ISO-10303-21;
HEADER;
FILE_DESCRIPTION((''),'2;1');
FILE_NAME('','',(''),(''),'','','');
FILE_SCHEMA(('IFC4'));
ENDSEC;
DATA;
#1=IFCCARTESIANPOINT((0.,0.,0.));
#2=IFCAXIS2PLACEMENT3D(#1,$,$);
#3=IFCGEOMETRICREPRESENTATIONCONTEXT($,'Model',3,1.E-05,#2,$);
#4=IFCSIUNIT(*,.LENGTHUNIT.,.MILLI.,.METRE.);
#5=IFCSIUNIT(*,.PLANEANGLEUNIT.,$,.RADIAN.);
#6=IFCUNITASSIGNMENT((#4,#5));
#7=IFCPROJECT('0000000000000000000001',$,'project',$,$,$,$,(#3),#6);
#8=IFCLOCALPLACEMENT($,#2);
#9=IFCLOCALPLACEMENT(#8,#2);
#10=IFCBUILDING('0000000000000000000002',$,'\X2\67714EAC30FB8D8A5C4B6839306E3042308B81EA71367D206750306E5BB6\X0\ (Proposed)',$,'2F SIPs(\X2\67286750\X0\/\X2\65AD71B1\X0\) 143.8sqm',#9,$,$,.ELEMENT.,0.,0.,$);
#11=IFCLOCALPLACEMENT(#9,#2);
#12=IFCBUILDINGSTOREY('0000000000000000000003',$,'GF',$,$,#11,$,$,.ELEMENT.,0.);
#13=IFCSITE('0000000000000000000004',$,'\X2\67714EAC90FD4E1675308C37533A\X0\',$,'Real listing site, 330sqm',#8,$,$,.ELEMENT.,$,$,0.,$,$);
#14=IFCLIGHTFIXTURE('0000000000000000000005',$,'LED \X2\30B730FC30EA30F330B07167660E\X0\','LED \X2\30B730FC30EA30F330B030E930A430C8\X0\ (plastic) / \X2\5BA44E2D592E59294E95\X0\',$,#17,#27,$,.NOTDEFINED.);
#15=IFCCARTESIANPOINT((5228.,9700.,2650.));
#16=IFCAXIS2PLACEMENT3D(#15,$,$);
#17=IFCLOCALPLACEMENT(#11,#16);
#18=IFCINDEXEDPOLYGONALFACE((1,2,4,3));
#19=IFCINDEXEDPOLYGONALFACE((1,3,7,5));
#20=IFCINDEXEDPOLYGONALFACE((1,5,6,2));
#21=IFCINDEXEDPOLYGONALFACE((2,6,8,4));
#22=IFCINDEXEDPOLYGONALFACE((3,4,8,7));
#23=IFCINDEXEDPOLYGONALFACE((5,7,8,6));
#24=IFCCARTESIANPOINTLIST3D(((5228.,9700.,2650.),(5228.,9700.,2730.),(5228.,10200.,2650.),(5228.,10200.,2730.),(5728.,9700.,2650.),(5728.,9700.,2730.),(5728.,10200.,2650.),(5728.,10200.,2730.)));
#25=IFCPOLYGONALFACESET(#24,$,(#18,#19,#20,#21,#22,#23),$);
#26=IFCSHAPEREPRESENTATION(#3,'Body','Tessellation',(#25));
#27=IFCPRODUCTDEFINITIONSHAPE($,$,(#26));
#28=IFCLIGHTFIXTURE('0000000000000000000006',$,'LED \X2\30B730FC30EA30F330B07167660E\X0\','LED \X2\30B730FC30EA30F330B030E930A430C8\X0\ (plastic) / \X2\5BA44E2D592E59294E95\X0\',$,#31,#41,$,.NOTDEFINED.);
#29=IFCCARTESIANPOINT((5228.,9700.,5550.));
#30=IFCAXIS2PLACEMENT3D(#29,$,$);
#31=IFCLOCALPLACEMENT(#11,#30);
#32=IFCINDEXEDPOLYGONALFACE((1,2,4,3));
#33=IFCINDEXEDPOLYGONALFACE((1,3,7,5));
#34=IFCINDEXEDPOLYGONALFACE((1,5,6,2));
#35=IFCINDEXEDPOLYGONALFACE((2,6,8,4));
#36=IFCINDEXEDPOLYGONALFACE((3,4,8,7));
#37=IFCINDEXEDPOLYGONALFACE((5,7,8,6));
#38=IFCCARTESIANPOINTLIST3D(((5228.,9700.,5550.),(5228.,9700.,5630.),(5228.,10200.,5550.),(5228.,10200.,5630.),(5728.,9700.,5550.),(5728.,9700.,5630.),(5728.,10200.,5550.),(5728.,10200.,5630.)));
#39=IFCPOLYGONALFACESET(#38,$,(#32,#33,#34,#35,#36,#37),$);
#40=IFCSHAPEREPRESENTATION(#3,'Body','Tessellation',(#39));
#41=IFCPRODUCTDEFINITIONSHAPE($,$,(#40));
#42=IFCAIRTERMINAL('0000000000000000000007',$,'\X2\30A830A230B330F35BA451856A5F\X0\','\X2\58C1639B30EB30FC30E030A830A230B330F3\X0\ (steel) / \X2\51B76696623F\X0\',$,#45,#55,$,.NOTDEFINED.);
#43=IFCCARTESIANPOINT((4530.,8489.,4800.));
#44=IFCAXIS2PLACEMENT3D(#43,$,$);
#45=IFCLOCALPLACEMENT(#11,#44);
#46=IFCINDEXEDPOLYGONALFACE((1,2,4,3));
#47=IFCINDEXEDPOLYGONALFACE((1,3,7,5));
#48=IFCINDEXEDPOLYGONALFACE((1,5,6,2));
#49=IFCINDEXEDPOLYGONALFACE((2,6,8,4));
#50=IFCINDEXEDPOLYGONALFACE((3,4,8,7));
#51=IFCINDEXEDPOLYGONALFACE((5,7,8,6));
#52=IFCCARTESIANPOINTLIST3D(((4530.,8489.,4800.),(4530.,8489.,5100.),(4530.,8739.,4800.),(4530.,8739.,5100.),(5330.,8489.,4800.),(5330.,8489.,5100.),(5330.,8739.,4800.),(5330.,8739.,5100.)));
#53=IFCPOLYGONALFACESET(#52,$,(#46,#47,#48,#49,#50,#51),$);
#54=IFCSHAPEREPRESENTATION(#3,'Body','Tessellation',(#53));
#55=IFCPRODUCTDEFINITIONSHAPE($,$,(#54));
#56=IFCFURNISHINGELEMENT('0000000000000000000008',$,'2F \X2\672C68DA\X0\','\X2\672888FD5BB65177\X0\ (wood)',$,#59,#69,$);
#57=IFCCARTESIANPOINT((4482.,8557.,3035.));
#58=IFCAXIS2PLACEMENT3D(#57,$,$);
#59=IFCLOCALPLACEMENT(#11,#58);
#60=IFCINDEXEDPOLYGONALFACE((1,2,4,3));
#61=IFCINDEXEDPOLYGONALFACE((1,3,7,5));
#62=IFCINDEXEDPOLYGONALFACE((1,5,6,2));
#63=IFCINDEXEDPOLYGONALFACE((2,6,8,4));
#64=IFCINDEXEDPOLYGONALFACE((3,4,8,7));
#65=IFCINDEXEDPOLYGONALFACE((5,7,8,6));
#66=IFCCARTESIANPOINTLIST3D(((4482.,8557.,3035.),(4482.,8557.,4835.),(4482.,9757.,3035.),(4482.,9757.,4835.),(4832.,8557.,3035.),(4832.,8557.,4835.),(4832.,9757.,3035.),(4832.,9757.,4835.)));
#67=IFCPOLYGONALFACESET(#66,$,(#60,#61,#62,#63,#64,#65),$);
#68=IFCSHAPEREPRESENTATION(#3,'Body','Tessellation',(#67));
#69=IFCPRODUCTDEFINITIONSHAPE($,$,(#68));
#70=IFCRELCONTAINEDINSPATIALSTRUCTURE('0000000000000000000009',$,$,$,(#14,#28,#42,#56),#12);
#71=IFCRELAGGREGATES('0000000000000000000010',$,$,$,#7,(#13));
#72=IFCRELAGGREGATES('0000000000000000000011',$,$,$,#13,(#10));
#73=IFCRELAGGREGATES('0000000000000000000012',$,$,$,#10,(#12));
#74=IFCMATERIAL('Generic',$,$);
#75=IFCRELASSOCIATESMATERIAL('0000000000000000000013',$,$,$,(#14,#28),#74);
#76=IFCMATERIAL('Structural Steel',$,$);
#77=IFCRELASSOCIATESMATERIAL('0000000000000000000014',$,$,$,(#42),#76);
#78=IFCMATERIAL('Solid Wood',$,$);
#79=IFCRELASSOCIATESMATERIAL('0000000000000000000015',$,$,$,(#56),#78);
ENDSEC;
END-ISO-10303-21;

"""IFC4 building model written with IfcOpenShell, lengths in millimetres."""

from ifc_helpers import new_model, si_unit, frame, frame_2d, origin, place, context, project, spatial, rectangle, extrude, material, element, save


model = new_model("IFC4")

# Units and contexts
model_context = context("Model", 3, precision=1e-05, world=origin())
ifc_project = project(units=[si_unit("LENGTHUNIT", "METRE", prefix="MILLI"), si_unit("PLANEANGLEUNIT", "RADIAN")], contexts=[model_context])

# Site, building, storey
site_placement = place(None, origin())
site = spatial("IfcSite", under=ifc_project, at=site_placement, Name="東京都世田谷区", ObjectType="Real listing site, 330sqm", CompositionType="ELEMENT", RefElevation=0.0)
building_placement = place(site_placement, origin())
building = spatial("IfcBuilding", under=site, at=building_placement, Name="東京・越屋根のある自然素材の家 (Proposed)", ObjectType="2F SIPs(木材/断熱) 143.8sqm", CompositionType="ELEMENT", ElevationOfRefHeight=0.0, ElevationOfTerrain=0.0)
storey_placement = place(building_placement, origin())
storey = spatial("IfcBuildingStorey", under=building, at=storey_placement, Name="GF", CompositionType="ELEMENT", Elevation=0.0)

# Shared definitions
ifc_material_1 = material(Name="Solid Wood")

# Shared definitions
ifc_material_2 = material(Name="Structural Steel")

# Shared definitions
ifc_material_3 = material(Name="Generic")

# Light fixtures
light_fixture_1_placement = place(storey_placement, frame((5228.0, 9700.0, 2650.0)))
element("IfcLightFixture", 1, at=light_fixture_1_placement, inside=storey, material=ifc_material_3, Name="LED シーリング照明", Description="LED シーリングライト (plastic) / 室中央天井", PredefinedType="NOTDEFINED", context=model_context, shape_type="SweptSolid", body=[
    extrude(rectangle(XDim=500.0, YDim=500.0, at=frame_2d((250.0, 250.0))), frame((5228.0, 9700.0, 2650.0)), (0.0, 0.0, 1.0), 80.0),
])
light_fixture_2_placement = place(storey_placement, frame((5228.0, 9700.0, 5550.0)))
element("IfcLightFixture", 2, at=light_fixture_2_placement, inside=storey, material=ifc_material_3, Name="LED シーリング照明", Description="LED シーリングライト (plastic) / 室中央天井", PredefinedType="NOTDEFINED", context=model_context, shape_type="SweptSolid", body=[
    extrude(rectangle(XDim=500.0, YDim=500.0, at=frame_2d((250.0, 250.0))), frame((5228.0, 9700.0, 5550.0)), (0.0, 0.0, 1.0), 80.0),
])

# Air terminal
air_terminal_placement = place(storey_placement, frame((4530.0, 8489.0, 4800.0)))
element("IfcAirTerminal", 3, at=air_terminal_placement, inside=storey, material=ifc_material_2, Name="エアコン室内機", Description="壁掛ルームエアコン (steel) / 冷暖房", PredefinedType="NOTDEFINED", context=model_context, shape_type="SweptSolid", body=[
    extrude(rectangle(XDim=800.0, YDim=250.0, at=frame_2d((400.0, 125.0))), frame((4530.0, 8489.0, 4800.0)), (0.0, 0.0, 1.0), 300.0),
])

# Furnishing element
furnishing_placement = place(storey_placement, frame((4482.0, 8557.0, 3035.0)))
element("IfcFurnishingElement", 4, at=furnishing_placement, inside=storey, material=ifc_material_1, Name="2F 本棚", Description="木製家具 (wood)", context=model_context, shape_type="SweptSolid", body=[
    extrude(rectangle(XDim=350.0, YDim=1200.0, at=frame_2d((175.0, 600.0))), frame((4482.0, 8557.0, 3035.0)), (0.0, 0.0, 1.0), 1800.0),
])

save(model, "model.ifc")
